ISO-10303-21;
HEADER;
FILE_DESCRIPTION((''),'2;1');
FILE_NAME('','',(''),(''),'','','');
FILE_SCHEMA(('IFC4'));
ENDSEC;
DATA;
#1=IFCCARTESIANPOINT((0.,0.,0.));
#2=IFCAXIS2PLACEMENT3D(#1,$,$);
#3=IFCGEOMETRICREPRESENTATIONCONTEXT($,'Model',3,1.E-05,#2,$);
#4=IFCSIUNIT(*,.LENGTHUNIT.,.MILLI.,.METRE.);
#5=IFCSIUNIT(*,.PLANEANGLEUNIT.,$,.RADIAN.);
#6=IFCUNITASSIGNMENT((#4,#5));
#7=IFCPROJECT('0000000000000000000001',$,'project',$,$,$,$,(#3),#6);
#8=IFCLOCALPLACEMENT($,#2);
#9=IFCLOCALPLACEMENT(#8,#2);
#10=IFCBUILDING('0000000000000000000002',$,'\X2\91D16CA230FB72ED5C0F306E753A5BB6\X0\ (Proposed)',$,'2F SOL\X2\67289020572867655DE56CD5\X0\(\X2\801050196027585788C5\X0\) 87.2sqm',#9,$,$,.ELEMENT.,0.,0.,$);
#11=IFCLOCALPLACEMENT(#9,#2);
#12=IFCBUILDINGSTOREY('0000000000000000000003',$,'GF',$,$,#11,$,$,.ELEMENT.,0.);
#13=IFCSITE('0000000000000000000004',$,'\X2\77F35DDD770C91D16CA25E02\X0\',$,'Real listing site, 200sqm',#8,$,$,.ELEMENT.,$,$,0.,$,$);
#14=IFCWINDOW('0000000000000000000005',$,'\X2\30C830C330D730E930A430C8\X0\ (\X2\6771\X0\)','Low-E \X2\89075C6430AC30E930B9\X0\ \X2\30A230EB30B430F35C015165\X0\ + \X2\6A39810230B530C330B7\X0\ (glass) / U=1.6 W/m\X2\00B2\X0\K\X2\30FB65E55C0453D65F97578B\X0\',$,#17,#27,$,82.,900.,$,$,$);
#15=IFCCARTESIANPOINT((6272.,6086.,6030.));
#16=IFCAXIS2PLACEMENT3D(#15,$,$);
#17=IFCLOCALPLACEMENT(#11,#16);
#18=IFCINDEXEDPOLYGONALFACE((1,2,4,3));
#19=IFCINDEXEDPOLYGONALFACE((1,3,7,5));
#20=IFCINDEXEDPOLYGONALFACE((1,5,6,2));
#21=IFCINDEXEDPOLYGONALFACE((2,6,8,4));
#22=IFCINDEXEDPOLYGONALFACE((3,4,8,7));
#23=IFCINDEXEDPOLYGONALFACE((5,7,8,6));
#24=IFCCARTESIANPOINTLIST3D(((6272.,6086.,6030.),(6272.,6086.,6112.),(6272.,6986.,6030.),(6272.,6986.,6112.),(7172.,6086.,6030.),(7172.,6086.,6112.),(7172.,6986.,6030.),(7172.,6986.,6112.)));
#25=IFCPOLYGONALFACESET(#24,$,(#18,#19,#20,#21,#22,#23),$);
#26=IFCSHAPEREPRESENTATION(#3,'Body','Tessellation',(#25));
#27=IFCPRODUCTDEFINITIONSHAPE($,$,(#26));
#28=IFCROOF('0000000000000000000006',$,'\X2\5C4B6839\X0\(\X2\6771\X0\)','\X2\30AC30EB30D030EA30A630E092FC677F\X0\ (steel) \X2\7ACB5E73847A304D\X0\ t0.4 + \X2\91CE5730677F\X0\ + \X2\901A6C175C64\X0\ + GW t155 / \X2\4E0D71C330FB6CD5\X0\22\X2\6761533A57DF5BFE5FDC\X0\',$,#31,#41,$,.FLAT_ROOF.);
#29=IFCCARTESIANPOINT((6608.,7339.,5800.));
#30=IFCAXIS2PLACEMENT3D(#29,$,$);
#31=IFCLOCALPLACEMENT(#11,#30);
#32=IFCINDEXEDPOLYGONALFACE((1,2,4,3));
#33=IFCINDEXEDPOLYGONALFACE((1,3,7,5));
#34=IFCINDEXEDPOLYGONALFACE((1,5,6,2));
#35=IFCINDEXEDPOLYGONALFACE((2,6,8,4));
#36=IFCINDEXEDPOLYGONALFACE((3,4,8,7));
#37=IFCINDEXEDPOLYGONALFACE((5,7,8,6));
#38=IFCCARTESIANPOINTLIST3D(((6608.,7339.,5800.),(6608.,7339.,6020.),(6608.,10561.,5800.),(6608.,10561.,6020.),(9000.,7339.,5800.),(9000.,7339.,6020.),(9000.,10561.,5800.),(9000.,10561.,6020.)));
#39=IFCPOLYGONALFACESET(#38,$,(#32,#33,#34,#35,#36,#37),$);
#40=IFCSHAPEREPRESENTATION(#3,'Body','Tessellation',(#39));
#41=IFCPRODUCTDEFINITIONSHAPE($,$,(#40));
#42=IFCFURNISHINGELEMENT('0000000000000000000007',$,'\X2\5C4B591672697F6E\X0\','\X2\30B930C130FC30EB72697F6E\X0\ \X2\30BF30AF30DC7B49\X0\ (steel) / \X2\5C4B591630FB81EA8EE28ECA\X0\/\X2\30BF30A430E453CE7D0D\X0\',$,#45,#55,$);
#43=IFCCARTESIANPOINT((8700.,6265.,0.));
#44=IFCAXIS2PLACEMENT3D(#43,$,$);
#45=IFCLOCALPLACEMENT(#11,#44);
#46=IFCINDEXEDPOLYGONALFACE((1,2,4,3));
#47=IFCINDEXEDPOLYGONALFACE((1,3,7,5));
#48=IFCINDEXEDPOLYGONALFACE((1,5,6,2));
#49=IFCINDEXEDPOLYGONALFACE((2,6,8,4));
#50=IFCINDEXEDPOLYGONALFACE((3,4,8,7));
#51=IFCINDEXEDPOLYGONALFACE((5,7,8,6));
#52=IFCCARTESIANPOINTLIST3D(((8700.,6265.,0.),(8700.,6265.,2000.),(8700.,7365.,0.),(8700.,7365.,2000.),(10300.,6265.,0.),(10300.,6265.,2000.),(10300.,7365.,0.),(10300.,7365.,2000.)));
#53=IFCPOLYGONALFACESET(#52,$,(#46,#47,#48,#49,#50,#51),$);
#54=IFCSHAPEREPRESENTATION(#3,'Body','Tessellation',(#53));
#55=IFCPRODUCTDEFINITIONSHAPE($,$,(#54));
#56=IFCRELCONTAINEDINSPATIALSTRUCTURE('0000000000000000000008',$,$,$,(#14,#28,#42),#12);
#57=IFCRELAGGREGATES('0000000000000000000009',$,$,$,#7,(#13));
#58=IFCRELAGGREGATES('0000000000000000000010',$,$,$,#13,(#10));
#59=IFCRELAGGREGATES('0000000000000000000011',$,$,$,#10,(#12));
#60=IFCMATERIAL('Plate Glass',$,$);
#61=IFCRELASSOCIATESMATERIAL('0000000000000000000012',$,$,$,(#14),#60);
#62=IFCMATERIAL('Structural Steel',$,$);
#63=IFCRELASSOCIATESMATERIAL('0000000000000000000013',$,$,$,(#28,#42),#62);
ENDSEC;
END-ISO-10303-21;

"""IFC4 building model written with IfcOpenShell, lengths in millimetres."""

from ifc_helpers import new_model, si_unit, frame, frame_2d, origin, place, context, project, spatial, rectangle, extrude, material, element, save


model = new_model("IFC4")

# Units and contexts
model_context = context("Model", 3, precision=1e-05, world=origin())
ifc_project = project(units=[si_unit("LENGTHUNIT", "METRE", prefix="MILLI"), si_unit("PLANEANGLEUNIT", "RADIAN")], contexts=[model_context])

# Site, building, storey
site_placement = place(None, origin())
site = spatial("IfcSite", under=ifc_project, at=site_placement, Name="石川県金沢市", ObjectType="Real listing site, 200sqm", CompositionType="ELEMENT", RefElevation=0.0)
building_placement = place(site_placement, origin())
building = spatial("IfcBuilding", under=site, at=building_placement, Name="金沢・狭小の町家 (Proposed)", ObjectType="2F SOL木造在来工法(耐候性塗装) 87.2sqm", CompositionType="ELEMENT", ElevationOfRefHeight=0.0, ElevationOfTerrain=0.0)
storey_placement = place(building_placement, origin())
storey = spatial("IfcBuildingStorey", under=building, at=storey_placement, Name="GF", CompositionType="ELEMENT", Elevation=0.0)

# Shared definitions
ifc_material_1 = material(Name="Plate Glass")

# Window
window_1_placement = place(storey_placement, frame((6272.0, 6086.0, 6030.0)))
element("IfcWindow", 1, at=window_1_placement, inside=storey, material=ifc_material_1, Name="トップライト (東)", Description="Low-E 複層ガラス アルゴン封入 + 樹脂サッシ (glass) / U=1.6 W/m²K・日射取得型", OverallHeight=82.0, OverallWidth=900.0, context=model_context, shape_type="SweptSolid", body=[
    extrude(rectangle(XDim=900.0, YDim=900.0, at=frame_2d((450.0, 450.0))), frame((6272.0, 6086.0, 6030.0)), (0.0, 0.0, 1.0), 82.0),
])

# Roof
ifc_material_2 = material(Name="Structural Steel")
for number, where, name in (
    (2, (6608.0, 7339.0, 5800.0), "屋根(東)"),
):
    element("IfcRoof", number, at=place(storey_placement, frame(where)), inside=storey, material=ifc_material_2, Name=name, Description="ガルバリウム鋼板 (steel) 立平葺き t0.4 + 野地板 + 通気層 + GW t155 / 不燃・法22条区域対応", PredefinedType="FLAT_ROOF", context=model_context, shape_type="SweptSolid", body=[
        extrude(rectangle(XDim=2392.0, YDim=3222.0, at=frame_2d((1196.0, 1611.0))), frame((6608.0, 7339.0, 5800.0)), (0.0, 0.0, 1.0), 220.0),
    ])

# Furnishing element
furnishing_placement = place(storey_placement, frame((8700.0, 6265.0, 0.0)))
element("IfcFurnishingElement", 3, at=furnishing_placement, inside=storey, material=ifc_material_2, Name="屋外物置", Description="スチール物置 タクボ等 (steel) / 屋外・自転車/タイヤ収納", context=model_context, shape_type="SweptSolid", body=[
    extrude(rectangle(XDim=1600.0, YDim=1100.0, at=frame_2d((800.0, 550.0))), frame((8700.0, 6265.0, 0.0)), (0.0, 0.0, 1.0), 2000.0),
])

save(model, "model.ifc")
